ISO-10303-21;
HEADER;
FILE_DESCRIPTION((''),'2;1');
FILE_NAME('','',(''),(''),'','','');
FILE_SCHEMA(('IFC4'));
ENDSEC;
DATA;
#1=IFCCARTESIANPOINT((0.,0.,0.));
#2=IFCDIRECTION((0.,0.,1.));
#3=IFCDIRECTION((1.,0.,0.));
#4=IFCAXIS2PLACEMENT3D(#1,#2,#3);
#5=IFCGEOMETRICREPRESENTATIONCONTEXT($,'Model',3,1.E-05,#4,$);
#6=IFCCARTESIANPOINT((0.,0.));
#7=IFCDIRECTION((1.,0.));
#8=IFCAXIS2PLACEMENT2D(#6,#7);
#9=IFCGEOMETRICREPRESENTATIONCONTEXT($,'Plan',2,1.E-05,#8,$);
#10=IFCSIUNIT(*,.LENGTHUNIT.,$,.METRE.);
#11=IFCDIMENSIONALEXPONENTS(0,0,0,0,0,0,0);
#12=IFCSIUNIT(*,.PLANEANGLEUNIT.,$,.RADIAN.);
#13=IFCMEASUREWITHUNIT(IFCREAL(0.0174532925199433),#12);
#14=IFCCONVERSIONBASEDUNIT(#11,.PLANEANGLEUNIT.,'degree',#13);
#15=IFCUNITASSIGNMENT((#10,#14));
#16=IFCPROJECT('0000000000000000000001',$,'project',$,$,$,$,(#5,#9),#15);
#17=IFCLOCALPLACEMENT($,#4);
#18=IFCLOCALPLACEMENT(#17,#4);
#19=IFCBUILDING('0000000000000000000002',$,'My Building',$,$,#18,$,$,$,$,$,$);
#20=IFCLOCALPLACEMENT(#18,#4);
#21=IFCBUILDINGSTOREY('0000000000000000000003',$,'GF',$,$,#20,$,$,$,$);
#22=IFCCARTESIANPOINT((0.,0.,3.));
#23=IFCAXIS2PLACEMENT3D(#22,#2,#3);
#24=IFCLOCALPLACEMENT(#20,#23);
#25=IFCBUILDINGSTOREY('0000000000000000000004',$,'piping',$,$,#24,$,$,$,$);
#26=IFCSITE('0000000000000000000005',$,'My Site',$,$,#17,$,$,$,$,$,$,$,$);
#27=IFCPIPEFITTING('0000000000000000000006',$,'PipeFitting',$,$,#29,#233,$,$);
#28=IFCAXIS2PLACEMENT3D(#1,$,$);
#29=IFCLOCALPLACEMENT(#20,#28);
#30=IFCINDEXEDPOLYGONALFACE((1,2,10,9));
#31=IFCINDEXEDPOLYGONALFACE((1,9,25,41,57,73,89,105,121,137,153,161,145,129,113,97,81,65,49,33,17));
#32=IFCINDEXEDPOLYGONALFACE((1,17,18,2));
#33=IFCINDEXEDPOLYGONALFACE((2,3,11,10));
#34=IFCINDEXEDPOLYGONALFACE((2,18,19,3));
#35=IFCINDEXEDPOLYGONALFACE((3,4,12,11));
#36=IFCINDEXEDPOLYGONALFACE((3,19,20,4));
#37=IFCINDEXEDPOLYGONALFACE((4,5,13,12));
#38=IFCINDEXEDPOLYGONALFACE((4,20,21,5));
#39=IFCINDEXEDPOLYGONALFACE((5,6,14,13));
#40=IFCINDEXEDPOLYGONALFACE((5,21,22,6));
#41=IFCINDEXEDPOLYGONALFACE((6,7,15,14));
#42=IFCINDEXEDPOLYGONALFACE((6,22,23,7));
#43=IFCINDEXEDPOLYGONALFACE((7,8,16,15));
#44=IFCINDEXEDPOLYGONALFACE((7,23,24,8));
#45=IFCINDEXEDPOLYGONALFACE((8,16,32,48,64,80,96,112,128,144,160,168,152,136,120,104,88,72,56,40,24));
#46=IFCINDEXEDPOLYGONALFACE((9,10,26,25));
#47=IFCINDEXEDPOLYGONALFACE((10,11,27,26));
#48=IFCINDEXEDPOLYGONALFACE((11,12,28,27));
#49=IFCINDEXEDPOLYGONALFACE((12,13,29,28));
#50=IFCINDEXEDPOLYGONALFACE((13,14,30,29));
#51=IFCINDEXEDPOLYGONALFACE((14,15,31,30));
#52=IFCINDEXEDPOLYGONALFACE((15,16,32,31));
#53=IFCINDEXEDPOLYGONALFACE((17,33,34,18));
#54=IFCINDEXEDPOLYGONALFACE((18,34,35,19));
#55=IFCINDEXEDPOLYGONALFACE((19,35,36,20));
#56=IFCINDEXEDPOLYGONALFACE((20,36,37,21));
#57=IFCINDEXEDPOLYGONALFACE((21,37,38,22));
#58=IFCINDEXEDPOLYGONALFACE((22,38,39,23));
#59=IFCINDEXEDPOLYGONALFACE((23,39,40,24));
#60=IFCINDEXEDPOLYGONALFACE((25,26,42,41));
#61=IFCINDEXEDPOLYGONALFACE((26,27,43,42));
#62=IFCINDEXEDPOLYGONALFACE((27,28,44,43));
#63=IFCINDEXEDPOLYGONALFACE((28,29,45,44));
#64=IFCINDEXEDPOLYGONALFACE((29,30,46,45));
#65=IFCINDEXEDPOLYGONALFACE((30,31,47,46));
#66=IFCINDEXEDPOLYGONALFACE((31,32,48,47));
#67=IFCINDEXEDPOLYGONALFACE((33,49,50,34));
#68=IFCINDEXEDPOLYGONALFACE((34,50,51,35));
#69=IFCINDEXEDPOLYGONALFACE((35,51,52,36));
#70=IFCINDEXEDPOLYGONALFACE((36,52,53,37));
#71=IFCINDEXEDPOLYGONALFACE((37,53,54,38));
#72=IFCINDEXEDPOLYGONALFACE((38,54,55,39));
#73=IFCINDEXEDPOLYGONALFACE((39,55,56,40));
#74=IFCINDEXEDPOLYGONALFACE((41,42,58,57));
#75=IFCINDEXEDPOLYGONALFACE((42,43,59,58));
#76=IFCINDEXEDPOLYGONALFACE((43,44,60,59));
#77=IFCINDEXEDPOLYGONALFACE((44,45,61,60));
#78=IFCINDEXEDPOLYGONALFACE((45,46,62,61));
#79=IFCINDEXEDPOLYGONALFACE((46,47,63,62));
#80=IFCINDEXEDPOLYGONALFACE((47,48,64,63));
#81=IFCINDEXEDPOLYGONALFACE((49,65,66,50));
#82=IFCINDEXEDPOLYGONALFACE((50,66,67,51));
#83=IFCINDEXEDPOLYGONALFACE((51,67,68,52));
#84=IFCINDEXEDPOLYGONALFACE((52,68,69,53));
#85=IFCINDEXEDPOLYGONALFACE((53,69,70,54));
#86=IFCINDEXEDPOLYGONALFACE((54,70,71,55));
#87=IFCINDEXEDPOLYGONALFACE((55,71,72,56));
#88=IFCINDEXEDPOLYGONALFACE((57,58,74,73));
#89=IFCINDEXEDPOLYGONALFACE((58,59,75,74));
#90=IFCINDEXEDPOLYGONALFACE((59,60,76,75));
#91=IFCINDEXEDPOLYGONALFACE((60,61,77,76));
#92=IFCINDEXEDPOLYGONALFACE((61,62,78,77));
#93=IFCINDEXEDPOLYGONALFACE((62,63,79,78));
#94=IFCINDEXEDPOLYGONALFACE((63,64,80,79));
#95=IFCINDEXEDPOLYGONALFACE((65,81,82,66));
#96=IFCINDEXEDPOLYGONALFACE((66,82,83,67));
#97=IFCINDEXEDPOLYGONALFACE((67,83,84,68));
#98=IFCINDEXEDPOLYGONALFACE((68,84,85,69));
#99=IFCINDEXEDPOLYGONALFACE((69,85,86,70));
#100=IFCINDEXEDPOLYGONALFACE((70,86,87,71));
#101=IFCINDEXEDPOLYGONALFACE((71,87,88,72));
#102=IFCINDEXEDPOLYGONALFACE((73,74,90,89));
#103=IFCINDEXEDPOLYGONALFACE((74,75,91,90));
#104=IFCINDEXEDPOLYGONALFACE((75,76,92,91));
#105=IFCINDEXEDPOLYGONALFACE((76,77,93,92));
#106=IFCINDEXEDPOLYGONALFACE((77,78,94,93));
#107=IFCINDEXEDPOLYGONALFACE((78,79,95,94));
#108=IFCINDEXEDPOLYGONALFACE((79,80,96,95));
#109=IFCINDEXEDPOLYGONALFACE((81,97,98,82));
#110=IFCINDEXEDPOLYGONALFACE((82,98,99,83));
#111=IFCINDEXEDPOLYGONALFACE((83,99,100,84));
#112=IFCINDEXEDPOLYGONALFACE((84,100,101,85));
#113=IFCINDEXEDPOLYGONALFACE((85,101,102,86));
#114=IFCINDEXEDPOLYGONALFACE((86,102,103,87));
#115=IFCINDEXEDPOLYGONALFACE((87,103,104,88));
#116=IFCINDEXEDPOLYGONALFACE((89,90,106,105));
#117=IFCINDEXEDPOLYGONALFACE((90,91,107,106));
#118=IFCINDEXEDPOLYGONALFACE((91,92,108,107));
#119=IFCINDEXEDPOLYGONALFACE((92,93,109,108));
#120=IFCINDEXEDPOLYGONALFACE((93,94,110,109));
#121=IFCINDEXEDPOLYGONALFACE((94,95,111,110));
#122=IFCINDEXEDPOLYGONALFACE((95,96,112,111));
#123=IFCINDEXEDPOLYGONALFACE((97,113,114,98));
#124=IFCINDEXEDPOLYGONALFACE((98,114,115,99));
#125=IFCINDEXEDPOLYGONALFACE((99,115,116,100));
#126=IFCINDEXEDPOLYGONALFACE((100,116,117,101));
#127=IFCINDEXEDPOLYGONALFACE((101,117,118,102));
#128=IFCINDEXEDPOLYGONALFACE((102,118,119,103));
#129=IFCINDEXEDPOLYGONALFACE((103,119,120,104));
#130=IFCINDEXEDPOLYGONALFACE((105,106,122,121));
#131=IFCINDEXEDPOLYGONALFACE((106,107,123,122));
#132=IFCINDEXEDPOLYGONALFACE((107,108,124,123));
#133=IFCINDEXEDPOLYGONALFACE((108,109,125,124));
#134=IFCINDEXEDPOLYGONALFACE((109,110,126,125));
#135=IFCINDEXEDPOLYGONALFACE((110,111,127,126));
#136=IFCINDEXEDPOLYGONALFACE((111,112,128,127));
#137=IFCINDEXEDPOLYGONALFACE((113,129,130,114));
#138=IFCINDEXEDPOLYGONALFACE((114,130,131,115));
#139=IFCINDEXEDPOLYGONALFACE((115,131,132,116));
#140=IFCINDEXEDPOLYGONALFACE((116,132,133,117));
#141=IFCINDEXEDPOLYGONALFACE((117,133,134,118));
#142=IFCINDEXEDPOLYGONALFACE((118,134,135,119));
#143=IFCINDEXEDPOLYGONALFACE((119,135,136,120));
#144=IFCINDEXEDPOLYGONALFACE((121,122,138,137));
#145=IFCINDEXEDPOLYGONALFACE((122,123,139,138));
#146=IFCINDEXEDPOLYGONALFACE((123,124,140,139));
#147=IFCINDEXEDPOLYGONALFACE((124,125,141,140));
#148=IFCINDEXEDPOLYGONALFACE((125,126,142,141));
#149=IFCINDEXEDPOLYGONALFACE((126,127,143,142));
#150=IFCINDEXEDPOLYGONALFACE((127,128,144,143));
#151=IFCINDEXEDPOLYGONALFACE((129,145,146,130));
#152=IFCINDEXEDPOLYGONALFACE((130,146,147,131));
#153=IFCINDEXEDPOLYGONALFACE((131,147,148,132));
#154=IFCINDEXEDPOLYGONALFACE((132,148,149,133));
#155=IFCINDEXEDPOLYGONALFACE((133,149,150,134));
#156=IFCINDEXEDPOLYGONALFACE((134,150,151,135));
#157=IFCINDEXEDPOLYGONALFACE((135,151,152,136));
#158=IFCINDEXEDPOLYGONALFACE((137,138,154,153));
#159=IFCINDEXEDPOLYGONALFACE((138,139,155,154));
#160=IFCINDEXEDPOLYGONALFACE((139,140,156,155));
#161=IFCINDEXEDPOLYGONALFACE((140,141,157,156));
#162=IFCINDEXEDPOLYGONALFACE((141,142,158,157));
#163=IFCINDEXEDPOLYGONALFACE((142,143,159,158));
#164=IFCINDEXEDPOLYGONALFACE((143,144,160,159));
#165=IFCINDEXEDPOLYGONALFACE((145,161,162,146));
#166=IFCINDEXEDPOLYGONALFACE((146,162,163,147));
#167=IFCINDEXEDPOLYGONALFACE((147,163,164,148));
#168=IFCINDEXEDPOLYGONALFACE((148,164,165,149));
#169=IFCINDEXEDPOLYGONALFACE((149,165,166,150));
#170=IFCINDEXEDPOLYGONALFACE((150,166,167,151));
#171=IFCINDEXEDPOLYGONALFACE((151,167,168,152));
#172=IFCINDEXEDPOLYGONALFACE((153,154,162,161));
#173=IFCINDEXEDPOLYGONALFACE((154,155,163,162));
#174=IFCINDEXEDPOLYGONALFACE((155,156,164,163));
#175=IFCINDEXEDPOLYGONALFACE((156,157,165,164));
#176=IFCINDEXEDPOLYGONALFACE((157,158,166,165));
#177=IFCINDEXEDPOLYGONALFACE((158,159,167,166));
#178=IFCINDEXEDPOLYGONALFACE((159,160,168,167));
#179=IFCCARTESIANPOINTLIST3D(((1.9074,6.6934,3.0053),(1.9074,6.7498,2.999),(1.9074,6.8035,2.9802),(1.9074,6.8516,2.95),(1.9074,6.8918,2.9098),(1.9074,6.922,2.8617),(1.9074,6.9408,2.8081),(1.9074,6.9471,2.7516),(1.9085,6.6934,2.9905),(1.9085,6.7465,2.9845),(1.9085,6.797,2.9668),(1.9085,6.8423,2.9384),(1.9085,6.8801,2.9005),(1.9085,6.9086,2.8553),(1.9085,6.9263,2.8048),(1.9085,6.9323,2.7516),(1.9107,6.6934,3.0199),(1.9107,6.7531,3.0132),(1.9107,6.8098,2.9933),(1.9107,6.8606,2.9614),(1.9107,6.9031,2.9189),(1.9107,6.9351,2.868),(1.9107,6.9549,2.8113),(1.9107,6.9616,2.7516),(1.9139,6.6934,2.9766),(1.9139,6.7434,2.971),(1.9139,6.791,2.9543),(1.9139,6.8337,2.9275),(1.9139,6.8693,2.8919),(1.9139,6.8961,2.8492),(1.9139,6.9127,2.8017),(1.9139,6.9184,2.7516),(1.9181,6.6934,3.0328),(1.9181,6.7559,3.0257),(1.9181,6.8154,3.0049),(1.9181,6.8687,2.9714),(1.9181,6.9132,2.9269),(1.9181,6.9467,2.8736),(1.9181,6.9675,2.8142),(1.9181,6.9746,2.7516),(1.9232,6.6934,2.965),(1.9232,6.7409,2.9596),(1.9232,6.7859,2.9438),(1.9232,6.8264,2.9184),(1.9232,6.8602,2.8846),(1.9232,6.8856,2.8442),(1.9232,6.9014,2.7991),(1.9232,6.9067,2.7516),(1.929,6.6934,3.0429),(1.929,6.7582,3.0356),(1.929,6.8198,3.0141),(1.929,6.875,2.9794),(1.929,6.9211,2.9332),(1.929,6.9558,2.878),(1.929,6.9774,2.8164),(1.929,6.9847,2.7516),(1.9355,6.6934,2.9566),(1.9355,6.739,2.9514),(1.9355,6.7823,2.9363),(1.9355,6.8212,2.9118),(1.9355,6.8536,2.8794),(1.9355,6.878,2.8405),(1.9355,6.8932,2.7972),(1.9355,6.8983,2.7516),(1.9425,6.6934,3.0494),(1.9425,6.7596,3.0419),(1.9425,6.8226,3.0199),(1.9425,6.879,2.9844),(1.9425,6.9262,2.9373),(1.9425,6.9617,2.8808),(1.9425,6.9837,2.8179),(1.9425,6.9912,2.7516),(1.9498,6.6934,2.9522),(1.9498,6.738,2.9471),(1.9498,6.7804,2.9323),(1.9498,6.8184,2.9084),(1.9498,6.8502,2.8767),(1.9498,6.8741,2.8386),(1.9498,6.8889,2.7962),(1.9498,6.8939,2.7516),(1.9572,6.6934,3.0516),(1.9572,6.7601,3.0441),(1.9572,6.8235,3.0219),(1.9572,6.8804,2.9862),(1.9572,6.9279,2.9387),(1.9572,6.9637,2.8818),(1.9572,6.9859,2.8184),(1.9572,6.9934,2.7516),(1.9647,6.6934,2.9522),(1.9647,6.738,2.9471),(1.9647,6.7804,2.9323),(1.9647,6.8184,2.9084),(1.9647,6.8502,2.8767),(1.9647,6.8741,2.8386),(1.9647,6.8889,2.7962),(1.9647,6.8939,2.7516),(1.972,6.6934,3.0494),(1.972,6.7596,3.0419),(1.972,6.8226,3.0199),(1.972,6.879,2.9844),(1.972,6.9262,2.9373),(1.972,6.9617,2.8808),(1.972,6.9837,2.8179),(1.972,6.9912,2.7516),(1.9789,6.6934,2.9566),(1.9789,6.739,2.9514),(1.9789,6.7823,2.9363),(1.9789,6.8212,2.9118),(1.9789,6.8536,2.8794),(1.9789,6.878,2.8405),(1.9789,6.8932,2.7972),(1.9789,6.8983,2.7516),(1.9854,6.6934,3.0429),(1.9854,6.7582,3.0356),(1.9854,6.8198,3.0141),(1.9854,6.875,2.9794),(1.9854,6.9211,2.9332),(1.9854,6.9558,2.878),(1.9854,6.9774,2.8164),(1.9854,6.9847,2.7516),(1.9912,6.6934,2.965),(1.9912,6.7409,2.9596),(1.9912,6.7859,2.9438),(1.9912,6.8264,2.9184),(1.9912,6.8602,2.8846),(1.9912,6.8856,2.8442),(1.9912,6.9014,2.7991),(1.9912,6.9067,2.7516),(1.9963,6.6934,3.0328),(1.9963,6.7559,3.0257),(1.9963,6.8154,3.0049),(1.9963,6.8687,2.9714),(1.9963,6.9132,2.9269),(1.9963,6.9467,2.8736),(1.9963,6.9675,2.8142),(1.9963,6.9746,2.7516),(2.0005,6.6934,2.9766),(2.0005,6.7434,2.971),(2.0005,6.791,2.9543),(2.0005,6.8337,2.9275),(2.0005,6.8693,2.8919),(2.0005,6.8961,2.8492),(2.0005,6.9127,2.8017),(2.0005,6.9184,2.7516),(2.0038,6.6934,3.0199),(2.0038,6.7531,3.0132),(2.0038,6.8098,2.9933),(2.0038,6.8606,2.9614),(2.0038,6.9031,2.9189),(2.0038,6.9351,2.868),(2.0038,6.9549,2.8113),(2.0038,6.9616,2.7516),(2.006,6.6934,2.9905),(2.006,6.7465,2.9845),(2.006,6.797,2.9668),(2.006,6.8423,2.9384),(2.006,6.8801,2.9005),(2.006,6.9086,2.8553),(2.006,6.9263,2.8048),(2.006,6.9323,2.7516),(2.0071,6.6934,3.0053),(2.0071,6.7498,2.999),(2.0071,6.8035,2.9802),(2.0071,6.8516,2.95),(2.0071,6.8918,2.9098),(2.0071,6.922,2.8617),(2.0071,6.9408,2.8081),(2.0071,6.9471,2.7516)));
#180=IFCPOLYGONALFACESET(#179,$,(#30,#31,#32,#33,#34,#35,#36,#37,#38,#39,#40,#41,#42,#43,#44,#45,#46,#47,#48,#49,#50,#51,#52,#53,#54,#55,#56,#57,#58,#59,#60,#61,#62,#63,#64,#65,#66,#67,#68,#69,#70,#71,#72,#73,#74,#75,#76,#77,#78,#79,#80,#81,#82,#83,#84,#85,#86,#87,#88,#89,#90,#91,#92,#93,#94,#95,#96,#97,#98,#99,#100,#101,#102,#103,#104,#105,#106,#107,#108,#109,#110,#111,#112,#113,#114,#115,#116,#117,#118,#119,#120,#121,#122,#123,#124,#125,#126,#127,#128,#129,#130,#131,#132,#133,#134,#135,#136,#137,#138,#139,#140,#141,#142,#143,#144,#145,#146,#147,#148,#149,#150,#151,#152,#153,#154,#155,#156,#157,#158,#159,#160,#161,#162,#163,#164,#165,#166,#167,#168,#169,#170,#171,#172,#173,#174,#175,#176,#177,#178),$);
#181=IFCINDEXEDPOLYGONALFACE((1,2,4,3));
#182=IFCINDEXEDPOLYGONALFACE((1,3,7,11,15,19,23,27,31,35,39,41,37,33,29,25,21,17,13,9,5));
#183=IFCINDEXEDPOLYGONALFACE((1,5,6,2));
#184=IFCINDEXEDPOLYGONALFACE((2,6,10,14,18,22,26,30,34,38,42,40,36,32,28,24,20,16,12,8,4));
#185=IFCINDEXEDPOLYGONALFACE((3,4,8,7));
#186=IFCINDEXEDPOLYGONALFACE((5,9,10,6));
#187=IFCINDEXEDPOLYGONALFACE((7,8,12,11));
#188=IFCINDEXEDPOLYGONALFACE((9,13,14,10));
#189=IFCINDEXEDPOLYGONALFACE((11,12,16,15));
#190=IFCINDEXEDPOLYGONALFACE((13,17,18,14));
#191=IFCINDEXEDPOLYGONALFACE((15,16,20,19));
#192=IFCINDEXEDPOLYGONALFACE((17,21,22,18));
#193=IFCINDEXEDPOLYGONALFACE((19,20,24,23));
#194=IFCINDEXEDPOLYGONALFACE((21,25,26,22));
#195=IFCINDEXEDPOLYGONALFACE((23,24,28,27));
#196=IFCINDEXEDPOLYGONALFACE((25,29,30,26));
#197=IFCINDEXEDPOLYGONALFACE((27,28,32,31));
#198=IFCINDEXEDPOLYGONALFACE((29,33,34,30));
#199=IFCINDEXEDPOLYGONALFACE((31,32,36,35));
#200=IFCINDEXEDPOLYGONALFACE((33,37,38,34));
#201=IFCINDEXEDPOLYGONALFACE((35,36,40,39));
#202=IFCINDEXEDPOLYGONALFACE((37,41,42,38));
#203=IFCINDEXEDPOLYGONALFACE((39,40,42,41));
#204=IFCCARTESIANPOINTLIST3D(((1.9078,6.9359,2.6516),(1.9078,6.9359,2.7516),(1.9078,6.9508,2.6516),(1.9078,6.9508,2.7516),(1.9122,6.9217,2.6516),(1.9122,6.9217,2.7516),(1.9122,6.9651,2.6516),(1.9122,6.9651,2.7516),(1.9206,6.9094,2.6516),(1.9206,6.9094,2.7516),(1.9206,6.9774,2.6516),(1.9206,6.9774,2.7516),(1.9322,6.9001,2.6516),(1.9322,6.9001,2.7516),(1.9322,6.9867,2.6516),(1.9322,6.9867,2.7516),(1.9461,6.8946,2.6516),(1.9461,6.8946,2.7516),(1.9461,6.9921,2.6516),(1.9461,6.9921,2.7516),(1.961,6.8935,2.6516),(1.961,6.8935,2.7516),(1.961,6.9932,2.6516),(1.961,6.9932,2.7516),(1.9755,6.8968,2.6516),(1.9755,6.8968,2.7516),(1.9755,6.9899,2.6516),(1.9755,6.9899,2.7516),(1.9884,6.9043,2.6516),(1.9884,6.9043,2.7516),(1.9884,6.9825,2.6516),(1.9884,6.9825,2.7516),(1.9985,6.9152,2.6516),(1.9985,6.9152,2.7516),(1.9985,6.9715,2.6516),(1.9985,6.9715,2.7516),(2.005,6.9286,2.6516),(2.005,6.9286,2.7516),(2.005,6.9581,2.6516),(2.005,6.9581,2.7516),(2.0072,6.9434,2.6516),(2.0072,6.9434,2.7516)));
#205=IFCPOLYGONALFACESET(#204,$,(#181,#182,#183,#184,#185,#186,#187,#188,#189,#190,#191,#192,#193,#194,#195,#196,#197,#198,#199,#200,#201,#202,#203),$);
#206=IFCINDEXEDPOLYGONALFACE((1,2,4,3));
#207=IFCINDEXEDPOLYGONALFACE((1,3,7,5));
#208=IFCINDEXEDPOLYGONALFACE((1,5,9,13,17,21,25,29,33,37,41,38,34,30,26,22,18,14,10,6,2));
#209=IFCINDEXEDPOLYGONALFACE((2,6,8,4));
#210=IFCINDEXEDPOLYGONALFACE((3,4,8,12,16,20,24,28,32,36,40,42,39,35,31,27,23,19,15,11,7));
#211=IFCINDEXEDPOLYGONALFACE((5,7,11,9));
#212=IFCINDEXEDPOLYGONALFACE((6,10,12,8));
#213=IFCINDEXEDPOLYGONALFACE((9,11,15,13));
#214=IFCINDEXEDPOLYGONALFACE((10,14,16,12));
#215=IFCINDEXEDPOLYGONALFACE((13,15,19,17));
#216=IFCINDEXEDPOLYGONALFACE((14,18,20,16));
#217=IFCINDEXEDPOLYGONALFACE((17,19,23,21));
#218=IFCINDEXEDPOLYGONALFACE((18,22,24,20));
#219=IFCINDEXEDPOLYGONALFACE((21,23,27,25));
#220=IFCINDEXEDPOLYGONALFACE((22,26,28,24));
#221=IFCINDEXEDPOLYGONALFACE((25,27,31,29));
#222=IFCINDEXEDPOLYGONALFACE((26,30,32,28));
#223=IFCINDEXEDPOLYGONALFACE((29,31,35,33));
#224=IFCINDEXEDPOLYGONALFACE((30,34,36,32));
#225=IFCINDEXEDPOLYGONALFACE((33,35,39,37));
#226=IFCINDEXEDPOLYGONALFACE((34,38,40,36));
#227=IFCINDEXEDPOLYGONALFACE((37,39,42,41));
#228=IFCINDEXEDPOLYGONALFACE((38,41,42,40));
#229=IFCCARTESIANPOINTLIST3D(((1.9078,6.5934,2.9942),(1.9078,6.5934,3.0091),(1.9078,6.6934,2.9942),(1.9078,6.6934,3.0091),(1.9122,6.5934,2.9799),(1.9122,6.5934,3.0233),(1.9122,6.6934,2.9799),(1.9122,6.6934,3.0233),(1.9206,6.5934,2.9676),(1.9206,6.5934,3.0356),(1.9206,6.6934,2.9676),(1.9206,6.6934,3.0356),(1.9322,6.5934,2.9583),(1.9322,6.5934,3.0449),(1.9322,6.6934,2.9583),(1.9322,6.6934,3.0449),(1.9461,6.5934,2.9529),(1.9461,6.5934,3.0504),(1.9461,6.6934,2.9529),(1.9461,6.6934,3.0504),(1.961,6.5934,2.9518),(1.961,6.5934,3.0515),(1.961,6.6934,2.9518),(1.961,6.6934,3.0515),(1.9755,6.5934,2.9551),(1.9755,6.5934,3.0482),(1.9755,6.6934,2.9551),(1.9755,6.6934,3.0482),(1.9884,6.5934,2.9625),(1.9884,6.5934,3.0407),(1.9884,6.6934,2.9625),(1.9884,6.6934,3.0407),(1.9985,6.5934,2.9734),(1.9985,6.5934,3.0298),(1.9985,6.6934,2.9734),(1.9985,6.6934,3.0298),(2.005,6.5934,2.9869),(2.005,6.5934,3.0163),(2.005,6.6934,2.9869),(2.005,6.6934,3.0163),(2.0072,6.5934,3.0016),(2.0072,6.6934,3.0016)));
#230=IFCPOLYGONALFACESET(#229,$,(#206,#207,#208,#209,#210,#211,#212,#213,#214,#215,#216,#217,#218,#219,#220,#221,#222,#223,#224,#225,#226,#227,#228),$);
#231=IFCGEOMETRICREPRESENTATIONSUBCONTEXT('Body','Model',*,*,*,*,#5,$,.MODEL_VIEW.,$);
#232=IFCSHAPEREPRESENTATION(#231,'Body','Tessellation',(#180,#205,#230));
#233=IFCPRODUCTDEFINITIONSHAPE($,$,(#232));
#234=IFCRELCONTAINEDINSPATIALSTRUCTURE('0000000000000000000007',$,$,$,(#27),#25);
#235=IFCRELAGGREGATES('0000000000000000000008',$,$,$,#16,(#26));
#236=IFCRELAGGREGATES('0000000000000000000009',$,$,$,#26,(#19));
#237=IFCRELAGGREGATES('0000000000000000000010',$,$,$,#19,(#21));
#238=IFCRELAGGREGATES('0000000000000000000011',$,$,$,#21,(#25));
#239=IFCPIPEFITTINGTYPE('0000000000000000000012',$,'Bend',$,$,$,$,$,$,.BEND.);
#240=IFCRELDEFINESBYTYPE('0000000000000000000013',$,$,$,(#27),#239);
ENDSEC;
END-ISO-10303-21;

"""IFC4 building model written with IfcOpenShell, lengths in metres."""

from ifc_helpers import new_model, entity, si_unit, converted_unit, frame, origin_with_axes, origin_2d_with_axis, place, context, subcontext, project, spatial, circle, extrude, source, transform, mapped, type_object, type_shapes, element, save


model = new_model("IFC4")

# Units and contexts
model_context = context("Model", 3, precision=1e-05, world=origin_with_axes())
plan_context = context("Plan", 2, precision=1e-05, world=origin_2d_with_axis())
body_context = subcontext(model_context, "Body", "Model", "MODEL_VIEW")
ifc_project = project(units=[si_unit("LENGTHUNIT", "METRE"), converted_unit("PLANEANGLEUNIT", "degree", entity("IfcReal", 0.0174532925199433), si_unit("PLANEANGLEUNIT", "RADIAN"), dimensions=[0, 0, 0, 0, 0, 0, 0])], contexts=[model_context, plan_context])

# Site, building, storeys
site_placement = place(None, origin_with_axes())
site = spatial("IfcSite", under=ifc_project, at=site_placement, Name="My Site")
building_placement = place(site_placement, origin_with_axes())
building = spatial("IfcBuilding", under=site, at=building_placement, Name="My Building")
storey_1_placement = place(building_placement, origin_with_axes())
storey_1 = spatial("IfcBuildingStorey", under=building, at=storey_1_placement, Name="GF")
storey_2_placement = place(storey_1_placement, frame((0.0, 0.0, 3.0), z_axis=(0.0, 0.0, 1.0), x_axis=(1.0, 0.0, 0.0)))
storey_2 = spatial("IfcBuildingStorey", under=storey_1, at=storey_2_placement, Name="piping")

# Pipe fitting
pipe_fitting_type = type_object("IfcPipeFittingType", Name="Bend", PredefinedType="BEND")
shared_shape = source(origin_with_axes(), body_context, "Body", "SolidModel", [
    entity("IfcSweptDiskSolid", entity("IfcIndexedPolyCurve", entity("IfcCartesianPointList3D", [[0.0, 0.0, -0.1], [0.0, 0.0732, -0.2768], [0.0, 0.25, -0.35]]), [entity("IfcArcIndex", [1, 2, 3])]), 0.05),
    extrude(circle(Radius=0.05), origin_with_axes(), (0.0, 0.0, -1.0), 0.1),
    extrude(circle(Radius=0.05), frame((0.0, 0.25, -0.35), z_axis=(0.0, 1.0, 0.0), x_axis=(1.0, 0.0, 0.0)), (0.0, 0.0, 1.0), 0.1),
])
type_shapes(pipe_fitting_type, [shared_shape])
for number, where, z_axis, x_axis, name in (
    (1, (1.9572, 6.9434, -0.3484), (0.0, 0.0, -1.0), (1.0, 0.0, 0.0), "PipeFitting"),
):
    element("IfcPipeFitting", number, at=place(storey_2_placement, frame(where, z_axis=z_axis, x_axis=x_axis)), inside=storey_2, type_object=pipe_fitting_type, Name=name, context=body_context, shape_type="MappedRepresentation", body=[
        mapped(shared_shape, transform((0.0, 0.0, 0.0), x_axis=(1.0, 0.0, 0.0), y_axis=(0.0, 1.0, 0.0), z_axis=(0.0, 0.0, 1.0), scale=1.0)),
    ])

save(model, "model.ifc")
